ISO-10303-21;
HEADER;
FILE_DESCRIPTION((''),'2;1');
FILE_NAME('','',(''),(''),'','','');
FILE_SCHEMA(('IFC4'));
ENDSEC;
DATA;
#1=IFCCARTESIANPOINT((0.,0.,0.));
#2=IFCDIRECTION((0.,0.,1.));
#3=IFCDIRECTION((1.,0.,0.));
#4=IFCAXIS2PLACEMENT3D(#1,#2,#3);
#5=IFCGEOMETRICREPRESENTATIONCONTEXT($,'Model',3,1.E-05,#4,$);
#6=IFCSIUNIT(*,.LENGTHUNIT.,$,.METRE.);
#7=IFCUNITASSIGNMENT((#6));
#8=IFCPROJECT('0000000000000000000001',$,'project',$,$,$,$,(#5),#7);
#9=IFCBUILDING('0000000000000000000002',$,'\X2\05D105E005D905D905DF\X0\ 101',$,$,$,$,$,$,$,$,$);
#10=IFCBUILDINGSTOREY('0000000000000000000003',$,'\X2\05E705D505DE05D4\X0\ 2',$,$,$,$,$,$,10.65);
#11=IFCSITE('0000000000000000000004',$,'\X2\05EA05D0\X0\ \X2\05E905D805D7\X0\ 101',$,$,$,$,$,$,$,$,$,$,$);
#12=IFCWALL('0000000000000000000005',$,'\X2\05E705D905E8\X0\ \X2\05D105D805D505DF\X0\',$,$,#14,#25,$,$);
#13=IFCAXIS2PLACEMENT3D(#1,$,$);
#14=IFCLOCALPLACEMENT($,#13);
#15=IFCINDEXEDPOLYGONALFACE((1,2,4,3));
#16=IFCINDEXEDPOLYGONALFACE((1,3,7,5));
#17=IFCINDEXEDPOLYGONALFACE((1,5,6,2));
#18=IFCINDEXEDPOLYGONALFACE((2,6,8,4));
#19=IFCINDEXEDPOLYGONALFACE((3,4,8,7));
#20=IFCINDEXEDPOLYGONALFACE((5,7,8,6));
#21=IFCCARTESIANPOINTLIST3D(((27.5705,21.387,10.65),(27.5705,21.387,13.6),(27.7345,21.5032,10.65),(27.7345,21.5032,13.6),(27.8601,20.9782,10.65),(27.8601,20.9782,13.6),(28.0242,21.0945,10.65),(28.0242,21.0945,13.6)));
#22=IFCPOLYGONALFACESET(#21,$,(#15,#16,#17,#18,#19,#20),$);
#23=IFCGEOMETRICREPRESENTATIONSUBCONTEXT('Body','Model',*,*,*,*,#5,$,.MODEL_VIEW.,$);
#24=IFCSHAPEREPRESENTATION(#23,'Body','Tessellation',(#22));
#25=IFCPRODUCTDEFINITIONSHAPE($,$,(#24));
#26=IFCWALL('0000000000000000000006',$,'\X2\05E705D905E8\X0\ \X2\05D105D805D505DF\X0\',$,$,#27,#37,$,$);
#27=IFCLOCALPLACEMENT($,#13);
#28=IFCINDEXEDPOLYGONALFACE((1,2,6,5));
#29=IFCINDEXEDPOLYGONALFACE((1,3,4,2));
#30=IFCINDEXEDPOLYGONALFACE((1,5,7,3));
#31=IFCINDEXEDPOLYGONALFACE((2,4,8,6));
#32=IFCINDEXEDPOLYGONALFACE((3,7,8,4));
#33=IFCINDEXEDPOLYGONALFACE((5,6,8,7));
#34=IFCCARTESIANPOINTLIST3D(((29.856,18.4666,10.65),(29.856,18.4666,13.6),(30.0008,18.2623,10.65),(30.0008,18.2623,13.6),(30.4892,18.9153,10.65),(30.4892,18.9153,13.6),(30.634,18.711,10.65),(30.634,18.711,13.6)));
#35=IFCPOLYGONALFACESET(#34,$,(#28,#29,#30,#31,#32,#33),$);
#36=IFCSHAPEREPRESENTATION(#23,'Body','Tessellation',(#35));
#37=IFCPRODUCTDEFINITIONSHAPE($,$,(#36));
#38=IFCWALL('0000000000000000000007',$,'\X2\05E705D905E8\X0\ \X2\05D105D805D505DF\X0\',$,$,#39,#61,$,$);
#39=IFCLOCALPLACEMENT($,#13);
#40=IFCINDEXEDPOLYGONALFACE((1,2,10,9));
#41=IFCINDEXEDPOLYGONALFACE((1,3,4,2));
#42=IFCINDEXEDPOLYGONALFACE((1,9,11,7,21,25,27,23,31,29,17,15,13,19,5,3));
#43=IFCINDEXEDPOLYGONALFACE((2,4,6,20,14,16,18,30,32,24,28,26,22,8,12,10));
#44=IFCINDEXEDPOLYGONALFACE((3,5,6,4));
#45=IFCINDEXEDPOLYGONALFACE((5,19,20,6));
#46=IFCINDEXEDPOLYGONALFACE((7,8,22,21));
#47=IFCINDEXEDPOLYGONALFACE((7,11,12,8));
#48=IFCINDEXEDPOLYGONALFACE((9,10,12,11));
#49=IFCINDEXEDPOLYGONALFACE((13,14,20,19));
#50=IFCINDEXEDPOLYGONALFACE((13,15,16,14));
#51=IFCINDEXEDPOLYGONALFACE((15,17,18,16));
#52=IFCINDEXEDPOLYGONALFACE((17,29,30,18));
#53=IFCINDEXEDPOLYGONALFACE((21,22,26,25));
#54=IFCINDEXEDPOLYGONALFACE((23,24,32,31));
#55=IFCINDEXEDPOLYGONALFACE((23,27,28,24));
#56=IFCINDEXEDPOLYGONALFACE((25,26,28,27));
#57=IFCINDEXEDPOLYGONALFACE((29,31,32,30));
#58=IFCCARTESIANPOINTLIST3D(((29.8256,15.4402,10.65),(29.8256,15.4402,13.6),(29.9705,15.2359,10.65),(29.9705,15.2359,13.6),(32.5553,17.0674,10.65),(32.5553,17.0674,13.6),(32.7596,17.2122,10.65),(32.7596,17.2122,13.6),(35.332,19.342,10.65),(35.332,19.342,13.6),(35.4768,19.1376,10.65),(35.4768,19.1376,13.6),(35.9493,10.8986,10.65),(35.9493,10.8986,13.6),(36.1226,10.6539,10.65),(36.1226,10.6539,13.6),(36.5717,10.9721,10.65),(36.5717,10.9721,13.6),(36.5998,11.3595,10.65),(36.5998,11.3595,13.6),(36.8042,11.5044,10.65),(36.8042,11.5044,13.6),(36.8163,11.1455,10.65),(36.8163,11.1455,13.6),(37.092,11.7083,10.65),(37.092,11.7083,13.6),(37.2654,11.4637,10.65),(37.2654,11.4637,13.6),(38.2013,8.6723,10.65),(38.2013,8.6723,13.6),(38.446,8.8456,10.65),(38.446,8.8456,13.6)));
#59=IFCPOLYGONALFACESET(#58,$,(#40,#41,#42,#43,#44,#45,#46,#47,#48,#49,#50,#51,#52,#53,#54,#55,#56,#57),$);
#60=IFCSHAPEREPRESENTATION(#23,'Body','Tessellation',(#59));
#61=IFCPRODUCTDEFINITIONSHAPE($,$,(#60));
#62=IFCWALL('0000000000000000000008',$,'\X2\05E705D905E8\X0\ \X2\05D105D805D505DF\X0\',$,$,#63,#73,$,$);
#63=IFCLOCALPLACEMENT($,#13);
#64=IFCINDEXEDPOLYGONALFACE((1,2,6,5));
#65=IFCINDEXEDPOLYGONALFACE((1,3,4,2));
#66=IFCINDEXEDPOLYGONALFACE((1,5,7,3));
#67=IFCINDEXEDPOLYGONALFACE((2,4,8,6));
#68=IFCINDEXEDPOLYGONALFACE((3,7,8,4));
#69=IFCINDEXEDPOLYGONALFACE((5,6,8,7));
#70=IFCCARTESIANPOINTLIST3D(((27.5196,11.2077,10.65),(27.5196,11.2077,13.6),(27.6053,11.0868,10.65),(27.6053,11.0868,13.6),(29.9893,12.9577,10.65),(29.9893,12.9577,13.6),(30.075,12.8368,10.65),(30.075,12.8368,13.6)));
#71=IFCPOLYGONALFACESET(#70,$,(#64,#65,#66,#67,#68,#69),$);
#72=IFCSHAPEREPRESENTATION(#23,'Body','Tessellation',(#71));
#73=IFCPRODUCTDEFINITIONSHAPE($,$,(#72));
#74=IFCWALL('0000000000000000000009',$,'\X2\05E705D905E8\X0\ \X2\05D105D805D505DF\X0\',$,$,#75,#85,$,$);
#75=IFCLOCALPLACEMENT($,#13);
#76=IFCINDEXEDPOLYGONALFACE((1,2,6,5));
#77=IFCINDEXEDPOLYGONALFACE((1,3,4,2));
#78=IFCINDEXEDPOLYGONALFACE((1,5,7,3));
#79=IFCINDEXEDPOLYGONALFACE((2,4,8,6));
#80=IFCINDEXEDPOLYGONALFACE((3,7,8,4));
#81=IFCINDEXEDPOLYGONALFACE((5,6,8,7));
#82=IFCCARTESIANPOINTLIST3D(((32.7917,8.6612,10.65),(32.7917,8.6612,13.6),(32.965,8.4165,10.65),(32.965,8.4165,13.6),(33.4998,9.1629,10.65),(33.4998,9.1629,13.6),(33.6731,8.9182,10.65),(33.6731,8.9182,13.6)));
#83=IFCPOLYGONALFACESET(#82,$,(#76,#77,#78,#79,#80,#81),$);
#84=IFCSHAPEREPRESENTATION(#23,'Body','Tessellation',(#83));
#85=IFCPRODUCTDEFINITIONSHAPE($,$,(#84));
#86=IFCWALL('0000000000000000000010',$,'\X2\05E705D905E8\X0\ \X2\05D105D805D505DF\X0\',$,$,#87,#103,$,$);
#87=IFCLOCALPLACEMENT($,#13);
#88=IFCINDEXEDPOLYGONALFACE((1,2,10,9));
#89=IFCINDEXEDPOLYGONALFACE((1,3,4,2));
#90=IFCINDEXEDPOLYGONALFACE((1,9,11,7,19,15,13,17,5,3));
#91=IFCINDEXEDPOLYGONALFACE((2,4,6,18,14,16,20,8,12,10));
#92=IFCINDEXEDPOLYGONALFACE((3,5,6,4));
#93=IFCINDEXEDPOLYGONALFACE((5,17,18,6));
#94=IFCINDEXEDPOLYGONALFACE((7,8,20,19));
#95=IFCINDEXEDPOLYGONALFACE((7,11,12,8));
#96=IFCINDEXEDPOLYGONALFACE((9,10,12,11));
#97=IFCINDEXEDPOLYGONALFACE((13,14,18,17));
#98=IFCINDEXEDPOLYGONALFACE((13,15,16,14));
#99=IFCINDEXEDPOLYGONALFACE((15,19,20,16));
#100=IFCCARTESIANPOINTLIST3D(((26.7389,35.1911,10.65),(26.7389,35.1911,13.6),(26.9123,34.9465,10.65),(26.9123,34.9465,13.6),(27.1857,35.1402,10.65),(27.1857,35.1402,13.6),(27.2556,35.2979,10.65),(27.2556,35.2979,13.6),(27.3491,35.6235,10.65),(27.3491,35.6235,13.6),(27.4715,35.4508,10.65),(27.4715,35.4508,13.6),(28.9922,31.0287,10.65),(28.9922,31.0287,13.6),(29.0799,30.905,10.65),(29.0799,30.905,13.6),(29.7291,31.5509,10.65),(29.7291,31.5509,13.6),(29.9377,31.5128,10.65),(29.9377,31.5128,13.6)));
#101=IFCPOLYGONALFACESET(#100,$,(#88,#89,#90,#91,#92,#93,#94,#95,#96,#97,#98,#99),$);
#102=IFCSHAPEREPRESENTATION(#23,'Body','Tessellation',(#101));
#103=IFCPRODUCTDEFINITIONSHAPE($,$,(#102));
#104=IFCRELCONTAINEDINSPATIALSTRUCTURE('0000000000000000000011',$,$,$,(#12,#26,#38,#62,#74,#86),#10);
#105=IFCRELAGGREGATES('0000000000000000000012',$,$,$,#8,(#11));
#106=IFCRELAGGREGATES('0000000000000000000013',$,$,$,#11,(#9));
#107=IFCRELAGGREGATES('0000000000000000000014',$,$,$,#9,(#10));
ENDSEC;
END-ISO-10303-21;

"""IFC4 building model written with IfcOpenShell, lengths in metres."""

from ifc_helpers import new_model, si_unit, frame, origin_with_axes, context, subcontext, project, spatial, polyline, outline, extrude, element, save


model = new_model("IFC4")

# Units and contexts
model_context = context("Model", 3, precision=1e-05, world=origin_with_axes())
body_context = subcontext(model_context, "Body", "Model", "MODEL_VIEW")
ifc_project = project(units=[si_unit("LENGTHUNIT", "METRE")], contexts=[model_context])

# Site, building, storey
site = spatial("IfcSite", under=ifc_project, Name="תא שטח 101")
building = spatial("IfcBuilding", under=site, Name="בניין 101")
storey = spatial("IfcBuildingStorey", under=building, Name="קומה 2", Elevation=10.65)

# Walls
element("IfcWall", 1, inside=storey, Name="קיר בטון", context=body_context, shape_type="SweptSolid", body=[
    extrude(outline(polyline([(27.8601, 20.9782), (28.0242, 21.0945), (27.7345, 21.5032), (27.5705, 21.387), (27.8601, 20.9782)])), frame((0.0, 0.0, 10.65)), (0.0, 0.0, 1.0), 2.95),
])
element("IfcWall", 2, inside=storey, Name="קיר בטון", context=body_context, shape_type="SweptSolid", body=[
    extrude(outline(polyline([(29.856, 18.4666), (30.0008, 18.2623), (30.634, 18.711), (30.4892, 18.9153), (29.856, 18.4666)])), frame((0.0, 0.0, 10.65)), (0.0, 0.0, 1.0), 2.95),
])
element("IfcWall", 3, inside=storey, Name="קיר בטון", context=body_context, shape_type="SweptSolid", body=[
    extrude(outline(polyline([(29.8256, 15.4402), (29.9705, 15.2359), (32.5553, 17.0674), (36.5998, 11.3595), (35.9493, 10.8986), (36.1226, 10.6539), (36.5717, 10.9721), (38.2013, 8.6723), (38.446, 8.8456), (36.8163, 11.1455), (37.2654, 11.4637), (37.092, 11.7083), (36.8042, 11.5044), (32.7596, 17.2122), (35.4768, 19.1376), (35.332, 19.342), (29.8256, 15.4402)])), frame((0.0, 0.0, 10.65)), (0.0, 0.0, 1.0), 2.95),
])
element("IfcWall", 4, inside=storey, Name="קיר בטון", context=body_context, shape_type="SweptSolid", body=[
    extrude(outline(polyline([(30.075, 12.8368), (29.9893, 12.9577), (27.5196, 11.2077), (27.6053, 11.0868), (30.075, 12.8368)])), frame((0.0, 0.0, 10.65)), (0.0, 0.0, 1.0), 2.95),
])
element("IfcWall", 5, inside=storey, Name="קיר בטון", context=body_context, shape_type="SweptSolid", body=[
    extrude(outline(polyline([(33.6731, 8.9182), (33.4998, 9.1629), (32.7917, 8.6612), (32.965, 8.4165), (33.6731, 8.9182)])), frame((0.0, 0.0, 10.65)), (0.0, 0.0, 1.0), 2.95),
])
element("IfcWall", 6, inside=storey, Name="קיר בטון", context=body_context, shape_type="SweptSolid", body=[
    extrude(outline(polyline([(27.1857, 35.1402), (29.7291, 31.5509), (28.9922, 31.0287), (29.0799, 30.905), (29.9377, 31.5128), (27.2556, 35.2979), (27.4715, 35.4508), (27.3491, 35.6235), (26.7389, 35.1911), (26.9123, 34.9465), (27.1857, 35.1402)])), frame((0.0, 0.0, 10.65)), (0.0, 0.0, 1.0), 2.95),
])

save(model, "model.ifc")
